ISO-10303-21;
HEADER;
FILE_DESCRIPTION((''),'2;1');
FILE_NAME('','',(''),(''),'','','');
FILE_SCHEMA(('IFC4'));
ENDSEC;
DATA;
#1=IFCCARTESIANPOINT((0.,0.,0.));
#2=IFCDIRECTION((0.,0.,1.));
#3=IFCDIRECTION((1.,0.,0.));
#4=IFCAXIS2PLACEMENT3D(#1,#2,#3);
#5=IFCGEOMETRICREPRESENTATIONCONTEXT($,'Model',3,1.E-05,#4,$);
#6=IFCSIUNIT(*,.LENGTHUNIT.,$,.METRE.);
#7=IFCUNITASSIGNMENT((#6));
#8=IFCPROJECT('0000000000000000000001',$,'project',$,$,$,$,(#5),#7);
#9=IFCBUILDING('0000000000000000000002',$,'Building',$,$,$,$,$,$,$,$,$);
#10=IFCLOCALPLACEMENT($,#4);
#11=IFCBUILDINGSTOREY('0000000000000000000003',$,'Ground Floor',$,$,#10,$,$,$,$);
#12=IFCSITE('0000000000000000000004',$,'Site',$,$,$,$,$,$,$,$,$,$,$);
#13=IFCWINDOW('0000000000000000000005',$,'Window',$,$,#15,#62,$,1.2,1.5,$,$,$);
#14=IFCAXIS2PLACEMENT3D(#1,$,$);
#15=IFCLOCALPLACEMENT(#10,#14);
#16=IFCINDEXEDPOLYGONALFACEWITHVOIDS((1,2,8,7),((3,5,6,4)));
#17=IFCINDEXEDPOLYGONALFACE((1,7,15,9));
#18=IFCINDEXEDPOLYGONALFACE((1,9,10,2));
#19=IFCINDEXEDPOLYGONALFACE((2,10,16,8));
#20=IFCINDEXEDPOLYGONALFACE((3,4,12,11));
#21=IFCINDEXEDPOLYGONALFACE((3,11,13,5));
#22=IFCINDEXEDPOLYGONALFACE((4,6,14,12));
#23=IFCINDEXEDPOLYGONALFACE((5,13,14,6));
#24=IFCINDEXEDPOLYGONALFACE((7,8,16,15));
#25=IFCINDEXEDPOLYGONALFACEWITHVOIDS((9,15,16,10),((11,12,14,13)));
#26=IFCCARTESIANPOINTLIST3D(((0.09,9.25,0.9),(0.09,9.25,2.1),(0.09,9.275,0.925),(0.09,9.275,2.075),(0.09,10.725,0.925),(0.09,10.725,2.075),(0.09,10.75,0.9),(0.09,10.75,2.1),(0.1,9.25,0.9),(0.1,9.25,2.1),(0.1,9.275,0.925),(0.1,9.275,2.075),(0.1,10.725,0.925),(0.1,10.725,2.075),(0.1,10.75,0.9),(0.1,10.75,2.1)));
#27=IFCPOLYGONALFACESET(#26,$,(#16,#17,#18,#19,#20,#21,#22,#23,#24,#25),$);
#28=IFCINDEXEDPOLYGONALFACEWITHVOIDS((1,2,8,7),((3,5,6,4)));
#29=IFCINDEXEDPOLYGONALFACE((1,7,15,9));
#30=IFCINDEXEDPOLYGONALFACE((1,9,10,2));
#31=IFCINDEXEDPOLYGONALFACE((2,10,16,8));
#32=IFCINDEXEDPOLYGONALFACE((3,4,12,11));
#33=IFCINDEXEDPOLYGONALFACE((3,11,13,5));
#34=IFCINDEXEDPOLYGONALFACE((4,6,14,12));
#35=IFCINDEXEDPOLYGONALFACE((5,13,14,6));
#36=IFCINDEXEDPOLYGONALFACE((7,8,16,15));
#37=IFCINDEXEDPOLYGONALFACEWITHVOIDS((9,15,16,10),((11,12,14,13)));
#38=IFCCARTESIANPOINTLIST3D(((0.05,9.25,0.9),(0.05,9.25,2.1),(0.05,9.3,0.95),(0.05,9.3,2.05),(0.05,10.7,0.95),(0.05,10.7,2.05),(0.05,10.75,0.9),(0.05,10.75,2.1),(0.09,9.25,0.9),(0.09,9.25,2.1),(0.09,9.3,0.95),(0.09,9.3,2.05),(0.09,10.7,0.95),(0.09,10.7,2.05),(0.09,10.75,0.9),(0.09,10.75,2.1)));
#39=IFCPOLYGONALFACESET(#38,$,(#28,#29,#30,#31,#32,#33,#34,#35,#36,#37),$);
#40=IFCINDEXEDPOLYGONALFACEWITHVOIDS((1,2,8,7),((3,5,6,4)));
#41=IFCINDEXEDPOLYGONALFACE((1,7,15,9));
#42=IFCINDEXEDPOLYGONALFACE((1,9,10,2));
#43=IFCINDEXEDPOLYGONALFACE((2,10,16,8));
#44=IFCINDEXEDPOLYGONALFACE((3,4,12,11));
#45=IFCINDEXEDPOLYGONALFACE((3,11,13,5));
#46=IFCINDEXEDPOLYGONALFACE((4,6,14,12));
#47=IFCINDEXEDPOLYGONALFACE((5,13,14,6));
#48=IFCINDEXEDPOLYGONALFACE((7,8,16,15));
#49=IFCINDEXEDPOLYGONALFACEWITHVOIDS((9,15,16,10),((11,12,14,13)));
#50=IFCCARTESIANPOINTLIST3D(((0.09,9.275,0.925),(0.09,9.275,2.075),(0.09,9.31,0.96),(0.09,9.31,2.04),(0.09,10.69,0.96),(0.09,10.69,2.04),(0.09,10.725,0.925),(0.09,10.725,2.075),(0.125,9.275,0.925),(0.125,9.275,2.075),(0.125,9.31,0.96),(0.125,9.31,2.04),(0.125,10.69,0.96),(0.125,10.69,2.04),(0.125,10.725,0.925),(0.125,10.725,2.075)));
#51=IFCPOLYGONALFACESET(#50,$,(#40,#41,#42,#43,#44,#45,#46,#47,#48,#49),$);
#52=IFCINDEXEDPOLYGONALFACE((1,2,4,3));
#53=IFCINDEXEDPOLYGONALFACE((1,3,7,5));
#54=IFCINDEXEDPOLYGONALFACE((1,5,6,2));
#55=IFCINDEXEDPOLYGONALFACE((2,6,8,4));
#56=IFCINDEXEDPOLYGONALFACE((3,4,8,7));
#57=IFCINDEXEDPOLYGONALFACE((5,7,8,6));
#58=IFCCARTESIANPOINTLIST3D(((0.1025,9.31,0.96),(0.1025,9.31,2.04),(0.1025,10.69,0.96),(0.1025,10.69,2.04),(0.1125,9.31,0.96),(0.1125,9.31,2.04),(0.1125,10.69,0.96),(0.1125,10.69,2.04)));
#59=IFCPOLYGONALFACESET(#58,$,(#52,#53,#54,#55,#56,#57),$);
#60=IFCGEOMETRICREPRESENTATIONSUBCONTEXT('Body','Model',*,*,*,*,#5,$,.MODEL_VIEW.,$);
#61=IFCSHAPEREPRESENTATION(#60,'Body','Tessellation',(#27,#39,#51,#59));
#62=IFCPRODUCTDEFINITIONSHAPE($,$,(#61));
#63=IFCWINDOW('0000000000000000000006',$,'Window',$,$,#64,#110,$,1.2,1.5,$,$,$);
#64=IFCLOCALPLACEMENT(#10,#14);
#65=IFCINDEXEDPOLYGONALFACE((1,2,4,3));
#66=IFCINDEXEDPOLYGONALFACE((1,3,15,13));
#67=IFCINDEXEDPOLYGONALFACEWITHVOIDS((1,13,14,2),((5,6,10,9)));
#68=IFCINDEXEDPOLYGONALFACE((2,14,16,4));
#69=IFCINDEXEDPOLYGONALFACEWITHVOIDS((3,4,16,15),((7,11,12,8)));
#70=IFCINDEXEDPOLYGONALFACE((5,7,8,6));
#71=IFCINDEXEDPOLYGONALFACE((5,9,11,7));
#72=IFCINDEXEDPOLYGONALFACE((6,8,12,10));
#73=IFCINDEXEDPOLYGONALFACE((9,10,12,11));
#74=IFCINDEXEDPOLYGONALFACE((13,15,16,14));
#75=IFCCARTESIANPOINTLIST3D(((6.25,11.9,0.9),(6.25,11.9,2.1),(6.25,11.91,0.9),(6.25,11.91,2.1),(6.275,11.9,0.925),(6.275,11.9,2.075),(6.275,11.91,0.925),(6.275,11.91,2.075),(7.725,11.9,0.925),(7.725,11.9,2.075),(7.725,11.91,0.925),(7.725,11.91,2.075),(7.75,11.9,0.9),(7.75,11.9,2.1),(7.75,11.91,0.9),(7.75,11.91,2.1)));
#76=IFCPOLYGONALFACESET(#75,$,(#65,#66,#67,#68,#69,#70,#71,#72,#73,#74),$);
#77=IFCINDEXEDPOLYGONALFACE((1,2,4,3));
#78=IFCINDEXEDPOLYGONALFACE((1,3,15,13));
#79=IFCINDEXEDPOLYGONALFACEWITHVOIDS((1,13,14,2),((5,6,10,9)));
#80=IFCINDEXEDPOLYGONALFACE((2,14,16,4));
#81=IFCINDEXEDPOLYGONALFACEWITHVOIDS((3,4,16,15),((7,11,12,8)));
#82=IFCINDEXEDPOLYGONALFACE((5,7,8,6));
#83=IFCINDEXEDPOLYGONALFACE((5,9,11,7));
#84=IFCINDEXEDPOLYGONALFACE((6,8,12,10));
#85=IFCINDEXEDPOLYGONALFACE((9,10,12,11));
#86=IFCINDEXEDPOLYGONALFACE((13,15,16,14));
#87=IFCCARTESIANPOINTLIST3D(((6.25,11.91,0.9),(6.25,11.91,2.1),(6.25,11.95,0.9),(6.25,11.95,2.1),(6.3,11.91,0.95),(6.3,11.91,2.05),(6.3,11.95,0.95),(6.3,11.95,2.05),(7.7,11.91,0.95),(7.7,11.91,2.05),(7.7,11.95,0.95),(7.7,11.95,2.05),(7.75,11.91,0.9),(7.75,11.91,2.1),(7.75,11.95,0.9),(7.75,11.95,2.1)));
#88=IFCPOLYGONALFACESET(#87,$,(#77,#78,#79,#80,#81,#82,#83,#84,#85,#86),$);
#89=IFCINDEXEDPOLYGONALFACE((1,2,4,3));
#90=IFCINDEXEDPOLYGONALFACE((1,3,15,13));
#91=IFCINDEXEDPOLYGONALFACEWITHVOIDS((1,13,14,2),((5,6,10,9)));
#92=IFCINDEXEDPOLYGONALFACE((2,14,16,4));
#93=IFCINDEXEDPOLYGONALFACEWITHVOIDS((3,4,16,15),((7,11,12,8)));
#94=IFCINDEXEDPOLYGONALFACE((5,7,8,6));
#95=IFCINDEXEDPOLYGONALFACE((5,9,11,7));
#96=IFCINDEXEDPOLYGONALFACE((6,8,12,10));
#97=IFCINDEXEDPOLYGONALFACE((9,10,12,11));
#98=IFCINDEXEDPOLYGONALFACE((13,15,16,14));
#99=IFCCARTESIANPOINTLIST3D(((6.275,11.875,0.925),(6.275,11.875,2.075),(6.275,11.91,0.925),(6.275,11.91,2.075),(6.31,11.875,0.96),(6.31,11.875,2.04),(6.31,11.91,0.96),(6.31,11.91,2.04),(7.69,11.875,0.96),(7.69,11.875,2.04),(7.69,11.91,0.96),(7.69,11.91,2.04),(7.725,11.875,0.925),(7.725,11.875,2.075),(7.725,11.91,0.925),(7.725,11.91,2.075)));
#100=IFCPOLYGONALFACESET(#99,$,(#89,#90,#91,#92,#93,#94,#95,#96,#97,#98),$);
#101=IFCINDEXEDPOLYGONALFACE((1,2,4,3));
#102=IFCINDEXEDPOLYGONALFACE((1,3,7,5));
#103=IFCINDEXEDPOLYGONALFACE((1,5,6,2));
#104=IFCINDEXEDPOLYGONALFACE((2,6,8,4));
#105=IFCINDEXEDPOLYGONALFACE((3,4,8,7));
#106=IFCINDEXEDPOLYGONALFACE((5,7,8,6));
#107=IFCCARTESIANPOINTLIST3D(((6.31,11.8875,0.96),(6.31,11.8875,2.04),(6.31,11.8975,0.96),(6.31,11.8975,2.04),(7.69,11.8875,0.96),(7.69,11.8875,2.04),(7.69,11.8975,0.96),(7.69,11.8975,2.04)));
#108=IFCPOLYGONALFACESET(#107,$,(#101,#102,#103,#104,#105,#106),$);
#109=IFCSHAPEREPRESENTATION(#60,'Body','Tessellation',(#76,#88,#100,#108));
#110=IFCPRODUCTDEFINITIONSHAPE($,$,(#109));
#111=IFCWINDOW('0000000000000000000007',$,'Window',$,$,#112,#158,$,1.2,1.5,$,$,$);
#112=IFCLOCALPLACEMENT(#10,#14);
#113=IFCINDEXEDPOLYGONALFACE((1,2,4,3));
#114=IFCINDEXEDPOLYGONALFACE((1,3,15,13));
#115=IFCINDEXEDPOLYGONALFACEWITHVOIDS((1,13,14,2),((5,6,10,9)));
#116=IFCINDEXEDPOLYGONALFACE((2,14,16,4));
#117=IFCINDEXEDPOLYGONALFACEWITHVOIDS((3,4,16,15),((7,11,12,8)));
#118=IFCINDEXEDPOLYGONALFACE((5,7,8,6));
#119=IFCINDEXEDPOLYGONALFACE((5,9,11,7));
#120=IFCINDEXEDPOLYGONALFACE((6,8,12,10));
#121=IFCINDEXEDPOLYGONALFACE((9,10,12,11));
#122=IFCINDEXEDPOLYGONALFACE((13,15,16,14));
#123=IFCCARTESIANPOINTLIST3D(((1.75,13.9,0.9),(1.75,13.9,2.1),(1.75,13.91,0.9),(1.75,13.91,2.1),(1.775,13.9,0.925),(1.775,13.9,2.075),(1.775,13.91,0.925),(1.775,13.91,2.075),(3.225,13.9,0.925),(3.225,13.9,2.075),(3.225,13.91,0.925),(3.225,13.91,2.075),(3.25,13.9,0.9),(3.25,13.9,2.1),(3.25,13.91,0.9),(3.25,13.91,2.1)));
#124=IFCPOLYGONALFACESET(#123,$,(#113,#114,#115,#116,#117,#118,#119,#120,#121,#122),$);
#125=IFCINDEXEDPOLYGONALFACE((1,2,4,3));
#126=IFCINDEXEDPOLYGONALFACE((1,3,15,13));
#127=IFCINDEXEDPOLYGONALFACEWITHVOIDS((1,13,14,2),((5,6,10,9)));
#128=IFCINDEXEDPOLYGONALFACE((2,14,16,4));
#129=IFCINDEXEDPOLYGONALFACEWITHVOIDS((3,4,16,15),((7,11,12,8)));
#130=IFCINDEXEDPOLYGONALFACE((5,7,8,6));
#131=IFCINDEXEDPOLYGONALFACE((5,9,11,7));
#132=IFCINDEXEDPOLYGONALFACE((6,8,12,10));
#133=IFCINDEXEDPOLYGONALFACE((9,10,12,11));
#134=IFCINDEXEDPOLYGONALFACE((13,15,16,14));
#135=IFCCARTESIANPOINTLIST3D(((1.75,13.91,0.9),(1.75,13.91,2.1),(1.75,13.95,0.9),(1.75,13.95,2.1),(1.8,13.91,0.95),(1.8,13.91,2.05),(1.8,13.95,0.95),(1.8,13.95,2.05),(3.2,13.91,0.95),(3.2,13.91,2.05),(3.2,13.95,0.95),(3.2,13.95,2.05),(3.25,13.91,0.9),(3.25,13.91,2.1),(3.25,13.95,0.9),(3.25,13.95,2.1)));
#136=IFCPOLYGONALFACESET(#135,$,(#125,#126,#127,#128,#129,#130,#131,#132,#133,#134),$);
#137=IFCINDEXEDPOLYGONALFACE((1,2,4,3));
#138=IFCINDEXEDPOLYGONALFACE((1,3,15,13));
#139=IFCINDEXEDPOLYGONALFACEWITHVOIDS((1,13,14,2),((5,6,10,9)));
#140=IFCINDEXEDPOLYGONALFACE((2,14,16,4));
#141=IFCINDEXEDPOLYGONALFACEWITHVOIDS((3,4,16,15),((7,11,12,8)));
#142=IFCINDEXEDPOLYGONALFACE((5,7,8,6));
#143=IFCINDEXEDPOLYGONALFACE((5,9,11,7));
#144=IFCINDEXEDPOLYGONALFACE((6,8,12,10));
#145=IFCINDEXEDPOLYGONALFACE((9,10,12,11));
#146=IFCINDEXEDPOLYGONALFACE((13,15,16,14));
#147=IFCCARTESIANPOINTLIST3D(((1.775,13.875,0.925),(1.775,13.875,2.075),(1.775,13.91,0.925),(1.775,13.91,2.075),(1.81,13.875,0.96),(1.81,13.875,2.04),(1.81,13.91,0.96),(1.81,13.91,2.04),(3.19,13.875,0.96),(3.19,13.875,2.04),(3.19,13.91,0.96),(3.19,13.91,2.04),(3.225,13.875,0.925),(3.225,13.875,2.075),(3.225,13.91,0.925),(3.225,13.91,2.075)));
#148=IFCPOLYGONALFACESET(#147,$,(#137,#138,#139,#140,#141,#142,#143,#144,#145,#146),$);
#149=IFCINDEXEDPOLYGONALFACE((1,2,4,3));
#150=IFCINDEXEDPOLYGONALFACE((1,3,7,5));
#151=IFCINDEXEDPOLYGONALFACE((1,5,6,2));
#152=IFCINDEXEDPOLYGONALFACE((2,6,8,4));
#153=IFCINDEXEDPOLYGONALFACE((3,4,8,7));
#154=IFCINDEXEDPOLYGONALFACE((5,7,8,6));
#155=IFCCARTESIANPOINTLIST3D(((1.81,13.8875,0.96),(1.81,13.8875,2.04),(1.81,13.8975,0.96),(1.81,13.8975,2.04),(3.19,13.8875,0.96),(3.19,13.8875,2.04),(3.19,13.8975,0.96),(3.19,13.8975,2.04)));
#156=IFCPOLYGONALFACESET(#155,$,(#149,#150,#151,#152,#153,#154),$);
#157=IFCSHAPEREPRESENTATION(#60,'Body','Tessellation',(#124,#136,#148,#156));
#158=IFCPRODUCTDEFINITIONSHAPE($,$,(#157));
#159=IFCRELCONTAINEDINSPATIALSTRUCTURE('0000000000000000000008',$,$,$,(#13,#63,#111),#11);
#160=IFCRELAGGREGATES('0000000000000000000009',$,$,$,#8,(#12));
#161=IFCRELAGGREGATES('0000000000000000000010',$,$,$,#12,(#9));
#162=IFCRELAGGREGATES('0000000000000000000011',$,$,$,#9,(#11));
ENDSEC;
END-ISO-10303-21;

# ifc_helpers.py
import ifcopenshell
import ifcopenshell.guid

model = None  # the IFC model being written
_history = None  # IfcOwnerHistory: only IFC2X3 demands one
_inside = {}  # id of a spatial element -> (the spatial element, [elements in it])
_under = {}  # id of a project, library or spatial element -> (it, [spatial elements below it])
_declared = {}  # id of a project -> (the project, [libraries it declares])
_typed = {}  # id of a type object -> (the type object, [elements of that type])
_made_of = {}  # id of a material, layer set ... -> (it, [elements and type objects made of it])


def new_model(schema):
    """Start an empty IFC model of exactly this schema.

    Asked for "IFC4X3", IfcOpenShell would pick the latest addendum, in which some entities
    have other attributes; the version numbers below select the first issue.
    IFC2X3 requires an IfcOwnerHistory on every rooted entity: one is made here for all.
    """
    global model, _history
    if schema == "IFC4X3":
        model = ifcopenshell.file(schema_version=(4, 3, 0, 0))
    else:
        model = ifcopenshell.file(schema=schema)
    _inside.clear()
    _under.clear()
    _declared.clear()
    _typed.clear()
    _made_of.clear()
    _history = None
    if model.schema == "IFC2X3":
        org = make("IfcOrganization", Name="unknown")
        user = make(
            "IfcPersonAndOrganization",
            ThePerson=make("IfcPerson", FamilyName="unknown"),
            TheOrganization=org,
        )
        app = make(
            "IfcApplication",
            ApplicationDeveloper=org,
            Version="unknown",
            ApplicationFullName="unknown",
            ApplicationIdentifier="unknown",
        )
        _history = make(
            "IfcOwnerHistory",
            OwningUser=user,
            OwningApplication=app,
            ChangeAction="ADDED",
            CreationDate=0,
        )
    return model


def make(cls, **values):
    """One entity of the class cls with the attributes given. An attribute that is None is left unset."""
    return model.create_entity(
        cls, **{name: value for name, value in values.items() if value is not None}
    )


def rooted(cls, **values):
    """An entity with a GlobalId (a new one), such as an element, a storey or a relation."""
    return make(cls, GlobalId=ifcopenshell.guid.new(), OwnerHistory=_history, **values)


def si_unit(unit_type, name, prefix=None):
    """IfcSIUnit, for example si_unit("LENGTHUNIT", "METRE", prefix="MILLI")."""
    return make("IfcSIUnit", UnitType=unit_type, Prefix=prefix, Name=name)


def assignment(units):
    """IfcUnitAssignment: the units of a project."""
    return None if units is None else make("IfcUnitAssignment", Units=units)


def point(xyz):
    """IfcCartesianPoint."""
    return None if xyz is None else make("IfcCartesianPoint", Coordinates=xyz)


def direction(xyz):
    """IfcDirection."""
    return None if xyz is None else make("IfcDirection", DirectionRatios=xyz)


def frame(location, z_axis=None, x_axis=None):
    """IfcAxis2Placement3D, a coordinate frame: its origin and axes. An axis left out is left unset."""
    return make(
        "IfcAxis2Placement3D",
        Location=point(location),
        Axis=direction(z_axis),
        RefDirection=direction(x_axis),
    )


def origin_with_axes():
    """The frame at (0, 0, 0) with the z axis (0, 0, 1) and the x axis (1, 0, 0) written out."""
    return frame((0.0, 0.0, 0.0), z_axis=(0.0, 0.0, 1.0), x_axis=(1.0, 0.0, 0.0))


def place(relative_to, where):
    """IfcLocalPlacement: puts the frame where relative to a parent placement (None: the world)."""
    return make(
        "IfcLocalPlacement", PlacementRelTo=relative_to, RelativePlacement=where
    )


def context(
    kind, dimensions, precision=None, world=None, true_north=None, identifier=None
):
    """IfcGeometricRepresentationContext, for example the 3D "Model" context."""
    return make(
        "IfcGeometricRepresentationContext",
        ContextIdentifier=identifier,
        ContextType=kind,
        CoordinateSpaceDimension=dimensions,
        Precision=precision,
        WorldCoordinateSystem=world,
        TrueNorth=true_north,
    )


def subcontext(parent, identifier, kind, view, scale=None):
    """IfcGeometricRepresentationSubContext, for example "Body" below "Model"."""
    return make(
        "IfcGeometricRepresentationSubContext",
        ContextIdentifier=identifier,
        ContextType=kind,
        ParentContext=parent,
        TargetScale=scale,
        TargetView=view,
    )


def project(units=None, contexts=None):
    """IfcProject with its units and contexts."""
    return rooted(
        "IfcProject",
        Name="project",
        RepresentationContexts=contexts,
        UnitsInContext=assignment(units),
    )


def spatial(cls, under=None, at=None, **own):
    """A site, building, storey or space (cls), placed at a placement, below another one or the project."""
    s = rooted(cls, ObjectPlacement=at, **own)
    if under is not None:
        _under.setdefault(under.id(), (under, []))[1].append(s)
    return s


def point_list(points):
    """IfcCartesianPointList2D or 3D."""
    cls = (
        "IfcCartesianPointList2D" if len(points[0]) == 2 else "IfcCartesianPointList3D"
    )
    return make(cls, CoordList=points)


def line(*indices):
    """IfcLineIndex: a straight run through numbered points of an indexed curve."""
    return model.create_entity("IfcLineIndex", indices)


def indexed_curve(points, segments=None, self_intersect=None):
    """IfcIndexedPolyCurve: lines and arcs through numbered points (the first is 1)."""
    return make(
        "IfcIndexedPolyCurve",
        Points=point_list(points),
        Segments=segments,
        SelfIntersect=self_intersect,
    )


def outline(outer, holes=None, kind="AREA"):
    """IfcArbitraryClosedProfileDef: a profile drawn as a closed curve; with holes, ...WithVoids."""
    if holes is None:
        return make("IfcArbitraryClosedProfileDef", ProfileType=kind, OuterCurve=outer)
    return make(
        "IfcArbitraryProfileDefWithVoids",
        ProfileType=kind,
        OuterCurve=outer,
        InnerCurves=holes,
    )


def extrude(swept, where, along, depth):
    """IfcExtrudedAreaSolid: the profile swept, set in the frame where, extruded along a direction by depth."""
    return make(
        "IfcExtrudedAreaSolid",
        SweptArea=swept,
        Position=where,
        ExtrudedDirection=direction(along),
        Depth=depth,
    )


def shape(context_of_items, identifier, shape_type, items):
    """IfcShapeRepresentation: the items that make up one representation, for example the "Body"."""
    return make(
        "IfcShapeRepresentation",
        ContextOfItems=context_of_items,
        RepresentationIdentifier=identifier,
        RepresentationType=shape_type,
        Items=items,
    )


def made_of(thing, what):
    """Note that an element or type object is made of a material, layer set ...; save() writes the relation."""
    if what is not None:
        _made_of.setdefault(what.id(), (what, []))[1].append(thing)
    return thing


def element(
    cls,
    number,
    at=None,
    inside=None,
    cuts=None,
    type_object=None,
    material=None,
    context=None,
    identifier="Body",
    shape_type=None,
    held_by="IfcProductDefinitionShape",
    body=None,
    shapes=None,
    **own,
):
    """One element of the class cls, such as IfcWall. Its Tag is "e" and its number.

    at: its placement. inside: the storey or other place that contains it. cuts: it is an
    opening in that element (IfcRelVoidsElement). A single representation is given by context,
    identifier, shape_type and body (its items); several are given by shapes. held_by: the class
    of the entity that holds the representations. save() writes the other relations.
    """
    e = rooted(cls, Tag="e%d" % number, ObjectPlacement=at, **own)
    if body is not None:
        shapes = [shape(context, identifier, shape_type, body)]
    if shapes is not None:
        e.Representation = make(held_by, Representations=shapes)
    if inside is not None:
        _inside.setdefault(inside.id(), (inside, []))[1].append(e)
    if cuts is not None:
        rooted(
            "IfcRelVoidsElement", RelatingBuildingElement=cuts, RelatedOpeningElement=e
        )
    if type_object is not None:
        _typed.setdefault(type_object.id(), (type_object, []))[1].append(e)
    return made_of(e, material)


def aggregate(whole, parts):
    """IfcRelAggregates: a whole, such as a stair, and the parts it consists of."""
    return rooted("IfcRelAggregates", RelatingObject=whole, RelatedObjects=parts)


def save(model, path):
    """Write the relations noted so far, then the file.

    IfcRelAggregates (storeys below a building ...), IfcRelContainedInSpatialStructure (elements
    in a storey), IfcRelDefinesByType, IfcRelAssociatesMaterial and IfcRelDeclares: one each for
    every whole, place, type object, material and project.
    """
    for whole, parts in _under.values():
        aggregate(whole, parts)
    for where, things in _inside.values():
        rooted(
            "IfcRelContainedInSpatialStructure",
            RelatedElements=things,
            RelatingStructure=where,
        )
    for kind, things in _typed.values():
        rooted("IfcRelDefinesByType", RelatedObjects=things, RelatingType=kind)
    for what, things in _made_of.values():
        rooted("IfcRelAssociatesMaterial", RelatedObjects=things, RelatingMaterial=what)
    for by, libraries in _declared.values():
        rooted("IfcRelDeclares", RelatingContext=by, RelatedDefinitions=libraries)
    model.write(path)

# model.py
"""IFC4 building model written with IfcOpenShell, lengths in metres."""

from ifc_helpers import new_model, si_unit, frame, origin_with_axes, place, context, subcontext, project, spatial, line, indexed_curve, outline, extrude, element, save


model = new_model("IFC4")

# Units and contexts
model_context = context("Model", 3, precision=1e-05, world=origin_with_axes())
body_context = subcontext(model_context, "Body", "Model", "MODEL_VIEW")
ifc_project = project(units=[si_unit("LENGTHUNIT", "METRE")], contexts=[model_context])

# Site, building, storey
site = spatial("IfcSite", under=ifc_project, Name="Site")
building = spatial("IfcBuilding", under=site, Name="Building")
storey_placement = place(None, origin_with_axes())
storey = spatial("IfcBuildingStorey", under=building, at=storey_placement, Name="Ground Floor")

# Windows
for number, where, z_axis, x_axis, name in (
    (1, (0.0, 10.75, 0.9), (0.0, 0.0, 1.0), (0.0, -1.0, 0.0), "Window"),
    (2, (7.75, 12.0, 0.9), (0.0, 0.0, 1.0), (-1.0, 0.0, 0.0), "Window"),
    (3, (3.25, 14.0, 0.9), (0.0, 0.0, 1.0), (-1.0, 0.0, 0.0), "Window"),
):
    element("IfcWindow", number, at=place(storey_placement, frame(where, z_axis=z_axis, x_axis=x_axis)), inside=storey, Name=name, OverallHeight=1.2, OverallWidth=1.5, context=body_context, shape_type="SweptSolid", body=[
        extrude(outline(indexed_curve([(0.0, 0.0), (1.5, 0.0), (1.5, 1.2), (0.0, 1.2)], segments=[line(1, 2, 3, 4, 1)]), holes=[indexed_curve([(0.025, 0.025), (1.475, 0.025), (1.475, 1.175), (0.025, 1.175)], segments=[line(1, 2, 3, 4, 1)])]), frame((0.0, 0.09, 0.0), z_axis=(0.0, -1.0, 0.0), x_axis=(1.0, 0.0, 0.0)), (0.0, 0.0, -1.0), 0.01),
        extrude(outline(indexed_curve([(0.0, 0.0), (1.5, 0.0), (1.5, 1.2), (0.0, 1.2)], segments=[line(1, 2, 3, 4, 1)]), holes=[indexed_curve([(0.05, 0.05), (1.45, 0.05), (1.45, 1.15), (0.05, 1.15)], segments=[line(1, 2, 3, 4, 1)])]), frame((0.0, 0.05, 0.0), z_axis=(0.0, -1.0, 0.0), x_axis=(1.0, 0.0, 0.0)), (0.0, 0.0, -1.0), 0.04),
        extrude(outline(indexed_curve([(0.0, 0.0), (1.45, 0.0), (1.45, 1.15), (0.0, 1.15)], segments=[line(1, 2, 3, 4, 1)]), holes=[indexed_curve([(0.035, 0.035), (1.415, 0.035), (1.415, 1.115), (0.035, 1.115)], segments=[line(1, 2, 3, 4, 1)])]), frame((0.025, 0.09, 0.025), z_axis=(0.0, -1.0, 0.0), x_axis=(1.0, 0.0, 0.0)), (0.0, 0.0, -1.0), 0.035),
        extrude(outline(indexed_curve([(0.035, 0.035), (1.415, 0.035), (1.415, 1.115), (0.035, 1.115)], segments=[line(1, 2, 3, 4, 1)])), frame((0.025, 0.1025, 0.025), z_axis=(0.0, -1.0, 0.0), x_axis=(1.0, 0.0, 0.0)), (0.0, 0.0, -1.0), 0.01),
    ])

save(model, "model.ifc")
